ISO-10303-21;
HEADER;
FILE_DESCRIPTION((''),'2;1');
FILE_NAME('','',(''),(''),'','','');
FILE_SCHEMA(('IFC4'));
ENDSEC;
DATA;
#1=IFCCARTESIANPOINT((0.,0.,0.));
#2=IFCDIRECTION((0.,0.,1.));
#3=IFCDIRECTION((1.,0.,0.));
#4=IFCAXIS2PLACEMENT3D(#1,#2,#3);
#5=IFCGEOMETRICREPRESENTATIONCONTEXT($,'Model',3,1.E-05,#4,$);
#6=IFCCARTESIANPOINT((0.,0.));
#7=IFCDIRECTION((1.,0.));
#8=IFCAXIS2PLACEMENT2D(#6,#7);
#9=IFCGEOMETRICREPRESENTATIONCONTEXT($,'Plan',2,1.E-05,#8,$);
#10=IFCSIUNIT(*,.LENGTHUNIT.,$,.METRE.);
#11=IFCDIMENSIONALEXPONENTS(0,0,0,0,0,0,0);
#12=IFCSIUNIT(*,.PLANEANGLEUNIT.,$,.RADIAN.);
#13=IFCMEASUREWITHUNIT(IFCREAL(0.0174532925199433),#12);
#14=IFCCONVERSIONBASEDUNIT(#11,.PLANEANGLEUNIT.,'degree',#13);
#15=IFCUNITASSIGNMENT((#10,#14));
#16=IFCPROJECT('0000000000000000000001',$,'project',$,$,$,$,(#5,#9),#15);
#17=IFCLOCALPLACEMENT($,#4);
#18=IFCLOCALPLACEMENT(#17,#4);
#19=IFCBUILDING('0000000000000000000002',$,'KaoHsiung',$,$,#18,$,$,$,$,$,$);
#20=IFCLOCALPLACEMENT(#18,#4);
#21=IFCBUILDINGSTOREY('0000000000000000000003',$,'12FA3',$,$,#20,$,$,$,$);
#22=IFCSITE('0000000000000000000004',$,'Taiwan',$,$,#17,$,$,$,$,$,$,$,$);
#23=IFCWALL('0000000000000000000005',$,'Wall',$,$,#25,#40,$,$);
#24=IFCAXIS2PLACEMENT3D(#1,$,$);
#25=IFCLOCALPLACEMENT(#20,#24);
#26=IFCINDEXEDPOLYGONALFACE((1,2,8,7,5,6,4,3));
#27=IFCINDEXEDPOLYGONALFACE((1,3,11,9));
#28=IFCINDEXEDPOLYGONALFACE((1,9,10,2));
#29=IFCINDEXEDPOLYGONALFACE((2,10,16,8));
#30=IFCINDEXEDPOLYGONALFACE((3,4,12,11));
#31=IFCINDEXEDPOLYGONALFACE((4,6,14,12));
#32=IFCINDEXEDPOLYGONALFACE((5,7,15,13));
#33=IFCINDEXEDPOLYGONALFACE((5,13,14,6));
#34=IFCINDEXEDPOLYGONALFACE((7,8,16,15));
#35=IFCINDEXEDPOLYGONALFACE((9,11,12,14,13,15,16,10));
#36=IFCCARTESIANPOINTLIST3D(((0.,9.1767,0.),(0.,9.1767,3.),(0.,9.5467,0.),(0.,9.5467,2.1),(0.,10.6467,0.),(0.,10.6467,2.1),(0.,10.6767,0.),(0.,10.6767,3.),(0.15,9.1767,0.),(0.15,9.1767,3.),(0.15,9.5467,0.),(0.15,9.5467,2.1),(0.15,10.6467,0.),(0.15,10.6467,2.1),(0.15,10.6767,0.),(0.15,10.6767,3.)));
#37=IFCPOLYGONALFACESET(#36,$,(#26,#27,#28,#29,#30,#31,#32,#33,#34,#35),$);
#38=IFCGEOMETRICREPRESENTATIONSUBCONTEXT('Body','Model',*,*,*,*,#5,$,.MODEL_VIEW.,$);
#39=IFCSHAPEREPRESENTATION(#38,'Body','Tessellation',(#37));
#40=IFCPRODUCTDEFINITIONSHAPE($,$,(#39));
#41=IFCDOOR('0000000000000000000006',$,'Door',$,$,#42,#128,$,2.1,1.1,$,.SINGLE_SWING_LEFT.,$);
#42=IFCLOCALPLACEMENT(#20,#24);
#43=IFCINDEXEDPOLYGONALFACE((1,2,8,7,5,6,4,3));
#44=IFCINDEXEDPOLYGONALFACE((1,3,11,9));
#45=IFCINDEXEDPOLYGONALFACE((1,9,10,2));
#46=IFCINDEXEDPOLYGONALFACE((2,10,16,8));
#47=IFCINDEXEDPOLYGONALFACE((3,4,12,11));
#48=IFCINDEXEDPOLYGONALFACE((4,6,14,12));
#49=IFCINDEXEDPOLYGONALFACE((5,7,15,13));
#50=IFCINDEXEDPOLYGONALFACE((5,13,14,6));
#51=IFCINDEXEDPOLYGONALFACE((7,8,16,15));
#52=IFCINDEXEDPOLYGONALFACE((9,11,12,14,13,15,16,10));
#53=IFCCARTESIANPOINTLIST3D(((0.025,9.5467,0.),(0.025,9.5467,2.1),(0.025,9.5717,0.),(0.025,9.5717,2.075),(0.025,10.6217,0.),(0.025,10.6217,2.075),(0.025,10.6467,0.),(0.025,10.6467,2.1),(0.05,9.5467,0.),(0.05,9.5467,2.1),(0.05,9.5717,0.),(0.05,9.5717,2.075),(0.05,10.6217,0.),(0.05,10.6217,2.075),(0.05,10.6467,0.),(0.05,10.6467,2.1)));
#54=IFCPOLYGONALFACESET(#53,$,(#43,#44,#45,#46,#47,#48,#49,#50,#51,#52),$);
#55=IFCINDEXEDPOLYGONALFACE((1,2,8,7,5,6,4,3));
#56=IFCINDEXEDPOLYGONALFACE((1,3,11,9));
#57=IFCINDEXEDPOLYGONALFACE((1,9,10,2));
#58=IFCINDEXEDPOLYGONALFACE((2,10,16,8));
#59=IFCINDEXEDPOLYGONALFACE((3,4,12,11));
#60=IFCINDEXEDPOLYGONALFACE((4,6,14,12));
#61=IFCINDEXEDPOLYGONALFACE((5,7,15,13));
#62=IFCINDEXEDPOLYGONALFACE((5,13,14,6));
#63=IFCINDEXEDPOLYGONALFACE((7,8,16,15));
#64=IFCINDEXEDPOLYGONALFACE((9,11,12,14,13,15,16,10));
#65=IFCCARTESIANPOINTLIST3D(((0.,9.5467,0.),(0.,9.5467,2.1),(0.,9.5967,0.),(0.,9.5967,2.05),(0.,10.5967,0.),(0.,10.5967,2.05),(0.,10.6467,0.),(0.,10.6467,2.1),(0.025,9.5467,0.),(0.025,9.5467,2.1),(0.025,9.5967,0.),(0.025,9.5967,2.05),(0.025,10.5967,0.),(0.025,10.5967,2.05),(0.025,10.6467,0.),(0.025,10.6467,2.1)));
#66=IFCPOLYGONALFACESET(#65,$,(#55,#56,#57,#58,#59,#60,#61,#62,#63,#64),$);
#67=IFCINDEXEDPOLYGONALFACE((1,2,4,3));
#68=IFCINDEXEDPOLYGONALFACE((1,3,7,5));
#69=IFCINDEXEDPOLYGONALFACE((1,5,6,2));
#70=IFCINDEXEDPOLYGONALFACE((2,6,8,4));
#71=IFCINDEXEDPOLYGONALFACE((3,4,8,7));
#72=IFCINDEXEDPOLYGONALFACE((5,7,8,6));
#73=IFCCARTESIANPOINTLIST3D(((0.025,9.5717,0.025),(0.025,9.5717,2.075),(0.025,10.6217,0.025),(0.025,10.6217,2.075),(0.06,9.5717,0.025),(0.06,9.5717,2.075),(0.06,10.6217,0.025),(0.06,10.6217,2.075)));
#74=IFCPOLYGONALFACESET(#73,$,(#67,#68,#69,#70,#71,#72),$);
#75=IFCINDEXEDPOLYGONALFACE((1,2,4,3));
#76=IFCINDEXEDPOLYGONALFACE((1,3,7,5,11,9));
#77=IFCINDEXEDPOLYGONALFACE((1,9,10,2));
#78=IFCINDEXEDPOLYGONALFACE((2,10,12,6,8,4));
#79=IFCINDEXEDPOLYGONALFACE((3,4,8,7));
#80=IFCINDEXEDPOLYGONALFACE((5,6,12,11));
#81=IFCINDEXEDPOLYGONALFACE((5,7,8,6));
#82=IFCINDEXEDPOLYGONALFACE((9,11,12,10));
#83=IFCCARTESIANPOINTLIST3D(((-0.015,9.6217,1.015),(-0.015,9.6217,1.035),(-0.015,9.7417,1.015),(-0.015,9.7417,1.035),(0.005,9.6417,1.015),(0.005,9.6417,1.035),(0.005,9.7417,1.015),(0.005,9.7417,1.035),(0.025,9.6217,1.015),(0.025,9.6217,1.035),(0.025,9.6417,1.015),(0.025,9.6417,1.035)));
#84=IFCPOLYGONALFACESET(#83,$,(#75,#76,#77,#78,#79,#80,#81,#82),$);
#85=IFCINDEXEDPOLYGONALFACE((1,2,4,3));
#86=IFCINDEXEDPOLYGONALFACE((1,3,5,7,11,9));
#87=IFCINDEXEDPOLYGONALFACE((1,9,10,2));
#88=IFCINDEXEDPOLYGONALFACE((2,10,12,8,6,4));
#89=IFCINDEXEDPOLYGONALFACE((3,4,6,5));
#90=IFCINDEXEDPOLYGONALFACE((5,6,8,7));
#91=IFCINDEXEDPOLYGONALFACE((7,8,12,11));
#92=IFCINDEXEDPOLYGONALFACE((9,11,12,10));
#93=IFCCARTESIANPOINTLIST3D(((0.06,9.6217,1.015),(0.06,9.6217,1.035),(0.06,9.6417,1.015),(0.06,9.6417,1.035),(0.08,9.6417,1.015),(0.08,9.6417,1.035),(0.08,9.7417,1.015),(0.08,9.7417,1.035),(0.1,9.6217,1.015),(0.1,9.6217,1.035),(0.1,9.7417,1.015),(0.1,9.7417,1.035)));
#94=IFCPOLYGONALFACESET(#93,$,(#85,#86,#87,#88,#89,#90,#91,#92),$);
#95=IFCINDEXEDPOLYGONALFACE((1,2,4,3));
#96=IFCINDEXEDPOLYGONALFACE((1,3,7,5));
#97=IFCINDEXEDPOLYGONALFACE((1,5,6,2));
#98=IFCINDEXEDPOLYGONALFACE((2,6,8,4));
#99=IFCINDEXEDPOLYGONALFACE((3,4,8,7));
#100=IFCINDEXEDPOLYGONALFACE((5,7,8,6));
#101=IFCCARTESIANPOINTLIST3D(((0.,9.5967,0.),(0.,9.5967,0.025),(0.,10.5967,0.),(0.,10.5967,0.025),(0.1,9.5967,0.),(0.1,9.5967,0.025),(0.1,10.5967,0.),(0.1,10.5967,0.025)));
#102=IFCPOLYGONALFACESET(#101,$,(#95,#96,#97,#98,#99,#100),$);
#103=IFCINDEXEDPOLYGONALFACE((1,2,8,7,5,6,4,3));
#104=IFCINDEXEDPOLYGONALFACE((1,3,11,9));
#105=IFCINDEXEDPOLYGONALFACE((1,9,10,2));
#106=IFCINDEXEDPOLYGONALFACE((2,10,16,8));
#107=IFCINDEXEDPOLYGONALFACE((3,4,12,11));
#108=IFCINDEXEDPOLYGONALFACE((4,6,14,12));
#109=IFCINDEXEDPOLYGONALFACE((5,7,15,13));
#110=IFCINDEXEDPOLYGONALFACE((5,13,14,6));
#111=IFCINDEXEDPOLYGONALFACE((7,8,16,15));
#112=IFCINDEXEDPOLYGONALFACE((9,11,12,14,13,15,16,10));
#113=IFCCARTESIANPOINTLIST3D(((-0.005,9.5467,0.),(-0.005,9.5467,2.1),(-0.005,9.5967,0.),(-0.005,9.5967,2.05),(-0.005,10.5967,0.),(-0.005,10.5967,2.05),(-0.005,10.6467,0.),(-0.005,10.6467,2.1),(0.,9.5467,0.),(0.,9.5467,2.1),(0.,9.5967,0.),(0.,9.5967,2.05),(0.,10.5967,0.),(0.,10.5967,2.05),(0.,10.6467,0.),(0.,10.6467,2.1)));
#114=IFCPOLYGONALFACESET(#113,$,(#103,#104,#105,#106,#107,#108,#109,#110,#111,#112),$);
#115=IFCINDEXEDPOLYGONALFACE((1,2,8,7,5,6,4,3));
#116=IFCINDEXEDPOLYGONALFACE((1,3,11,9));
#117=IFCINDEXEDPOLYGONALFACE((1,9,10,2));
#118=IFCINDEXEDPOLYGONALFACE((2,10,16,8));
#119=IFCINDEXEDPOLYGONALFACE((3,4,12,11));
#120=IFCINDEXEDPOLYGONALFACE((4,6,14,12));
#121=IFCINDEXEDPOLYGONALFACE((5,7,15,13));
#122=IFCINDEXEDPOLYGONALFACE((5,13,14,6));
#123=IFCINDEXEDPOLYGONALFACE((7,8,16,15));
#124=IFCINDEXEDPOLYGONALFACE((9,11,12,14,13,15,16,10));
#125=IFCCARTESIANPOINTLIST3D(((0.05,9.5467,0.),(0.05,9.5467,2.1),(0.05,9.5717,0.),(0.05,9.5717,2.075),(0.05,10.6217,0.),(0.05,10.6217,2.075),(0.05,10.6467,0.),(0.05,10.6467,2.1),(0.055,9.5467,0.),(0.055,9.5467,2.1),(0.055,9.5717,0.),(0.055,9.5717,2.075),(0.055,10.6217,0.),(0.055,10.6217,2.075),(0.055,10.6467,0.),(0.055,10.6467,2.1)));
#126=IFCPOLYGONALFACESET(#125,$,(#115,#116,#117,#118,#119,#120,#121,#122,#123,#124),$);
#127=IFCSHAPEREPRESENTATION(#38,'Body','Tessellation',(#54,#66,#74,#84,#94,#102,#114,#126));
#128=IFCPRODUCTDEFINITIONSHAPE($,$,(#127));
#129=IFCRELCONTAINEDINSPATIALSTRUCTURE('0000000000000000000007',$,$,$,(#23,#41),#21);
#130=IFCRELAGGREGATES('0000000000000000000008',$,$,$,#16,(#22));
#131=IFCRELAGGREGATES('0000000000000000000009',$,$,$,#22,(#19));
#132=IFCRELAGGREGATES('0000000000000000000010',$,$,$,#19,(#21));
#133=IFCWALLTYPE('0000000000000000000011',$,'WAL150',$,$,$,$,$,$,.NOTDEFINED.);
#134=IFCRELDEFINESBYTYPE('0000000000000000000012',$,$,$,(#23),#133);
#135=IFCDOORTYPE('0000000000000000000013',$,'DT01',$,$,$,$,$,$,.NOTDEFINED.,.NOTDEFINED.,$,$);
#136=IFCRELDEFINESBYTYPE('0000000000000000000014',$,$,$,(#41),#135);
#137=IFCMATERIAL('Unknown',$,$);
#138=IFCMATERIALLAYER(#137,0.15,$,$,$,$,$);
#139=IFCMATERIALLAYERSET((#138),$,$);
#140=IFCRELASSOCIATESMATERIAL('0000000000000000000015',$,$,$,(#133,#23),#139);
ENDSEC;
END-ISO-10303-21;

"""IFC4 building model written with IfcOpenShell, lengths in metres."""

from ifc_helpers import new_model, entity, si_unit, converted_unit, frame, origin_with_axes, origin_2d_with_axis, place, context, subcontext, project, spatial, line, indexed_curve, outline, extrude, shape, source, transform, mapped, material, layer, layer_set, layer_usage, type_object, type_shapes, element, fill, save


model = new_model("IFC4")

# Units and contexts
model_context = context("Model", 3, precision=1e-05, world=origin_with_axes())
plan_context = context("Plan", 2, precision=1e-05, world=origin_2d_with_axis())
body_context_1 = subcontext(model_context, "Body", "Model", "MODEL_VIEW")
body_context_2 = subcontext(plan_context, "Body", "Plan", "PLAN_VIEW")
ifc_project = project(units=[si_unit("LENGTHUNIT", "METRE"), converted_unit("PLANEANGLEUNIT", "degree", entity("IfcReal", 0.0174532925199433), si_unit("PLANEANGLEUNIT", "RADIAN"), dimensions=[0, 0, 0, 0, 0, 0, 0])], contexts=[model_context, plan_context])

# Site, building, storey
site_placement = place(None, origin_with_axes())
site = spatial("IfcSite", under=ifc_project, at=site_placement, Name="Taiwan")
building_placement = place(site_placement, origin_with_axes())
building = spatial("IfcBuilding", under=site, at=building_placement, Name="KaoHsiung")
storey_placement = place(building_placement, origin_with_axes())
storey = spatial("IfcBuildingStorey", under=building, at=storey_placement, Name="12FA3")

# Shared definitions
ifc_material = material(Name="Unknown")

# Shared definitions
ifc_layer_1 = layer(ifc_material, 0.15)
ifc_layer_set_1 = layer_set([ifc_layer_1])
wall_type_1 = type_object("IfcWallType", Name="WAL150", PredefinedType="NOTDEFINED", material=ifc_layer_set_1)

# Wall, opening, door
ifc_layer_usage_1 = layer_usage(ifc_layer_set_1, "AXIS2", "POSITIVE", 0.0)
wall_1_placement = place(storey_placement, frame((0.0, 10.6767, 0.0), z_axis=(0.0, 0.0, 1.0), x_axis=(0.0, -1.0, 0.0)))
wall_1 = element("IfcWall", 1, at=wall_1_placement, inside=storey, type_object=wall_type_1, material=ifc_layer_usage_1, Name="Wall", context=body_context_1, shape_type="SweptSolid", body=[
    extrude(outline(indexed_curve([(0.0, 0.0), (0.0, 0.15), (1.5, 0.15), (1.5, 0.0)], segments=[line(1, 2, 3, 4, 1)])), origin_with_axes(), (0.0, 0.0, 1.0), 3.0),
])
shared_shape_1 = source(origin_with_axes(), body_context_1, "Body", "SweptSolid", [
    extrude(outline(indexed_curve([(0.0, 0.0), (1.1, 0.0), (1.1, 2.1), (0.0, 2.1)], segments=[line(1, 2, 3, 4, 1)])), frame((0.0, -0.6, 0.0), z_axis=(0.0, -1.0, 0.0), x_axis=(1.0, 0.0, 0.0)), (0.0, 0.0, -1.0), 1.2),
])
opening_1_placement = place(wall_1_placement, frame((0.03, 0.0, 0.0), z_axis=(0.0, 0.0, 1.0), x_axis=(1.0, 0.0, 0.0)))
opening_1 = element("IfcOpeningElement", 2, at=opening_1_placement, cuts=wall_1, PredefinedType="OPENING", context=body_context_1, shape_type="MappedRepresentation", body=[
    mapped(shared_shape_1, transform((0.0, 0.0, 0.0), x_axis=(1.0, 0.0, 0.0), y_axis=(0.0, 1.0, 0.0), z_axis=(0.0, 0.0, 1.0), scale=1.0)),
])
door_type_1 = type_object("IfcDoorType", Name="DT01", OperationType="NOTDEFINED", PredefinedType="NOTDEFINED")
shared_shape_2 = source(origin_with_axes(), body_context_1, "Body", "SweptSolid", [
    extrude(outline(indexed_curve([(0.0, 0.0), (0.0, 2.1), (1.1, 2.1), (1.1, 0.0), (1.075, 0.0), (1.075, 2.075), (0.025, 2.075), (0.025, 0.0)], segments=[line(1, 2, 3, 4, 5, 6, 7, 8, 1)])), frame((0.0, 0.025, 0.0), z_axis=(0.0, -1.0, 0.0), x_axis=(1.0, 0.0, 0.0)), (0.0, 0.0, -1.0), 0.025),
    extrude(outline(indexed_curve([(0.0, 0.0), (0.0, 2.1), (1.1, 2.1), (1.1, 0.0), (1.05, 0.0), (1.05, 2.05), (0.05, 2.05), (0.05, 0.0)], segments=[line(1, 2, 3, 4, 5, 6, 7, 8, 1)])), frame((0.0, 0.0, 0.0), z_axis=(0.0, -1.0, 0.0), x_axis=(1.0, 0.0, 0.0)), (0.0, 0.0, -1.0), 0.025),
    extrude(outline(indexed_curve([(0.0, 0.0), (1.05, 0.0), (1.05, 0.035), (0.0, 0.035)], segments=[line(1, 2, 3, 4, 1)])), frame((0.025, 0.025, 0.025), z_axis=(0.0, 0.0, 1.0), x_axis=(1.0, 0.0, 0.0)), (0.0, 0.0, 1.0), 2.05),
    extrude(outline(indexed_curve([(0.0, 0.0), (0.0, -0.04), (-0.12, -0.04), (-0.12, -0.02), (-0.02, -0.02), (-0.02, 0.0)], segments=[line(1, 2, 3, 4, 5, 6, 1)])), frame((1.025, 0.025, 1.015), z_axis=(0.0, 0.0, 1.0), x_axis=(1.0, 0.0, 0.0)), (0.0, 0.0, 1.0), 0.02),
    extrude(outline(indexed_curve([(0.0, 0.0), (0.0, 0.04), (-0.12, 0.04), (-0.12, 0.02), (-0.02, 0.02), (-0.02, 0.0)], segments=[line(1, 2, 3, 4, 5, 6, 1)])), frame((1.025, 0.06, 1.015), z_axis=(0.0, 0.0, 1.0), x_axis=(1.0, 0.0, 0.0)), (0.0, 0.0, 1.0), 0.02),
    extrude(outline(indexed_curve([(0.0, 0.0), (1.0, 0.0), (1.0, 0.1), (0.0, 0.1)], segments=[line(1, 2, 3, 4, 1)])), frame((0.05, 0.0, 0.0), z_axis=(0.0, 0.0, 1.0), x_axis=(1.0, 0.0, 0.0)), (0.0, 0.0, 1.0), 0.025),
    extrude(outline(indexed_curve([(0.0, 0.0), (0.0, 2.1), (1.1, 2.1), (1.1, 0.0), (1.05, 0.0), (1.05, 2.05), (0.05, 2.05), (0.05, 0.0)], segments=[line(1, 2, 3, 4, 5, 6, 7, 8, 1)])), frame((0.0, -0.005, 0.0), z_axis=(0.0, -1.0, 0.0), x_axis=(1.0, 0.0, 0.0)), (0.0, 0.0, -1.0), 0.005),
    extrude(outline(indexed_curve([(0.0, 0.0), (0.0, 2.1), (1.1, 2.1), (1.1, 0.0), (1.075, 0.0), (1.075, 2.075), (0.025, 2.075), (0.025, 0.0)], segments=[line(1, 2, 3, 4, 5, 6, 7, 8, 1)])), frame((0.0, 0.05, 0.0), z_axis=(0.0, -1.0, 0.0), x_axis=(1.0, 0.0, 0.0)), (0.0, 0.0, -1.0), 0.005),
])
shared_shape_3 = source(origin_with_axes(), body_context_2, "Body", "Curve2D", [
    entity("IfcIndexedPolyCurve", entity("IfcCartesianPointList2D", [[0.0, 0.0], [0.0, 0.05], [0.025, 0.05], [0.025, 0.025], [0.05, 0.025], [0.05, 0.0]]), [entity("IfcLineIndex", [1, 2, 3, 4, 5, 6, 1])]),
    entity("IfcIndexedPolyCurve", entity("IfcCartesianPointList2D", [[1.1, 0.0], [1.1, 0.05], [1.075, 0.05], [1.075, 0.025], [1.05, 0.025], [1.05, 0.0]]), [entity("IfcLineIndex", [1, 2, 3, 4, 5, 6, 1])]),
    entity("IfcTrimmedCurve", entity("IfcEllipse", entity("IfcAxis2Placement2D", entity("IfcCartesianPoint", [0.06, 0.05]), entity("IfcDirection", [1.0, 0.0])), 1.015, 1.05), [entity("IfcCartesianPoint", [1.075, 0.05])], [entity("IfcCartesianPoint", [0.06, 1.1])], True, "CARTESIAN"),
    entity("IfcIndexedPolyCurve", entity("IfcCartesianPointList2D", [[0.025, 0.05], [0.06, 0.05], [0.06, 1.1], [0.025, 1.1]]), [entity("IfcLineIndex", [1, 2, 3, 4, 1])]),
])
type_shapes(door_type_1, [shared_shape_2, shared_shape_3])
door_1_placement = place(opening_1_placement, frame((0.0, 0.0, 0.0), z_axis=(0.0, 0.0, 1.0), x_axis=(1.0, 0.0, 0.0)))
door_1 = element("IfcDoor", 3, at=door_1_placement, inside=storey, type_object=door_type_1, Name="Door", OperationType="SINGLE_SWING_LEFT", OverallHeight=2.1, OverallWidth=1.1, shapes=[
    shape(body_context_1, "Body", "MappedRepresentation", [mapped(shared_shape_2, transform((0.0, 0.0, 0.0), x_axis=(1.0, 0.0, 0.0), y_axis=(0.0, 1.0, 0.0), z_axis=(0.0, 0.0, 1.0), scale=1.0))]),
    shape(body_context_2, "Body", "MappedRepresentation", [mapped(shared_shape_3, transform((0.0, 0.0, 0.0), x_axis=(1.0, 0.0, 0.0), y_axis=(0.0, 1.0, 0.0), z_axis=(0.0, 0.0, 1.0), scale=1.0))]),
])
fill(opening_1, door_1)

save(model, "model.ifc")
